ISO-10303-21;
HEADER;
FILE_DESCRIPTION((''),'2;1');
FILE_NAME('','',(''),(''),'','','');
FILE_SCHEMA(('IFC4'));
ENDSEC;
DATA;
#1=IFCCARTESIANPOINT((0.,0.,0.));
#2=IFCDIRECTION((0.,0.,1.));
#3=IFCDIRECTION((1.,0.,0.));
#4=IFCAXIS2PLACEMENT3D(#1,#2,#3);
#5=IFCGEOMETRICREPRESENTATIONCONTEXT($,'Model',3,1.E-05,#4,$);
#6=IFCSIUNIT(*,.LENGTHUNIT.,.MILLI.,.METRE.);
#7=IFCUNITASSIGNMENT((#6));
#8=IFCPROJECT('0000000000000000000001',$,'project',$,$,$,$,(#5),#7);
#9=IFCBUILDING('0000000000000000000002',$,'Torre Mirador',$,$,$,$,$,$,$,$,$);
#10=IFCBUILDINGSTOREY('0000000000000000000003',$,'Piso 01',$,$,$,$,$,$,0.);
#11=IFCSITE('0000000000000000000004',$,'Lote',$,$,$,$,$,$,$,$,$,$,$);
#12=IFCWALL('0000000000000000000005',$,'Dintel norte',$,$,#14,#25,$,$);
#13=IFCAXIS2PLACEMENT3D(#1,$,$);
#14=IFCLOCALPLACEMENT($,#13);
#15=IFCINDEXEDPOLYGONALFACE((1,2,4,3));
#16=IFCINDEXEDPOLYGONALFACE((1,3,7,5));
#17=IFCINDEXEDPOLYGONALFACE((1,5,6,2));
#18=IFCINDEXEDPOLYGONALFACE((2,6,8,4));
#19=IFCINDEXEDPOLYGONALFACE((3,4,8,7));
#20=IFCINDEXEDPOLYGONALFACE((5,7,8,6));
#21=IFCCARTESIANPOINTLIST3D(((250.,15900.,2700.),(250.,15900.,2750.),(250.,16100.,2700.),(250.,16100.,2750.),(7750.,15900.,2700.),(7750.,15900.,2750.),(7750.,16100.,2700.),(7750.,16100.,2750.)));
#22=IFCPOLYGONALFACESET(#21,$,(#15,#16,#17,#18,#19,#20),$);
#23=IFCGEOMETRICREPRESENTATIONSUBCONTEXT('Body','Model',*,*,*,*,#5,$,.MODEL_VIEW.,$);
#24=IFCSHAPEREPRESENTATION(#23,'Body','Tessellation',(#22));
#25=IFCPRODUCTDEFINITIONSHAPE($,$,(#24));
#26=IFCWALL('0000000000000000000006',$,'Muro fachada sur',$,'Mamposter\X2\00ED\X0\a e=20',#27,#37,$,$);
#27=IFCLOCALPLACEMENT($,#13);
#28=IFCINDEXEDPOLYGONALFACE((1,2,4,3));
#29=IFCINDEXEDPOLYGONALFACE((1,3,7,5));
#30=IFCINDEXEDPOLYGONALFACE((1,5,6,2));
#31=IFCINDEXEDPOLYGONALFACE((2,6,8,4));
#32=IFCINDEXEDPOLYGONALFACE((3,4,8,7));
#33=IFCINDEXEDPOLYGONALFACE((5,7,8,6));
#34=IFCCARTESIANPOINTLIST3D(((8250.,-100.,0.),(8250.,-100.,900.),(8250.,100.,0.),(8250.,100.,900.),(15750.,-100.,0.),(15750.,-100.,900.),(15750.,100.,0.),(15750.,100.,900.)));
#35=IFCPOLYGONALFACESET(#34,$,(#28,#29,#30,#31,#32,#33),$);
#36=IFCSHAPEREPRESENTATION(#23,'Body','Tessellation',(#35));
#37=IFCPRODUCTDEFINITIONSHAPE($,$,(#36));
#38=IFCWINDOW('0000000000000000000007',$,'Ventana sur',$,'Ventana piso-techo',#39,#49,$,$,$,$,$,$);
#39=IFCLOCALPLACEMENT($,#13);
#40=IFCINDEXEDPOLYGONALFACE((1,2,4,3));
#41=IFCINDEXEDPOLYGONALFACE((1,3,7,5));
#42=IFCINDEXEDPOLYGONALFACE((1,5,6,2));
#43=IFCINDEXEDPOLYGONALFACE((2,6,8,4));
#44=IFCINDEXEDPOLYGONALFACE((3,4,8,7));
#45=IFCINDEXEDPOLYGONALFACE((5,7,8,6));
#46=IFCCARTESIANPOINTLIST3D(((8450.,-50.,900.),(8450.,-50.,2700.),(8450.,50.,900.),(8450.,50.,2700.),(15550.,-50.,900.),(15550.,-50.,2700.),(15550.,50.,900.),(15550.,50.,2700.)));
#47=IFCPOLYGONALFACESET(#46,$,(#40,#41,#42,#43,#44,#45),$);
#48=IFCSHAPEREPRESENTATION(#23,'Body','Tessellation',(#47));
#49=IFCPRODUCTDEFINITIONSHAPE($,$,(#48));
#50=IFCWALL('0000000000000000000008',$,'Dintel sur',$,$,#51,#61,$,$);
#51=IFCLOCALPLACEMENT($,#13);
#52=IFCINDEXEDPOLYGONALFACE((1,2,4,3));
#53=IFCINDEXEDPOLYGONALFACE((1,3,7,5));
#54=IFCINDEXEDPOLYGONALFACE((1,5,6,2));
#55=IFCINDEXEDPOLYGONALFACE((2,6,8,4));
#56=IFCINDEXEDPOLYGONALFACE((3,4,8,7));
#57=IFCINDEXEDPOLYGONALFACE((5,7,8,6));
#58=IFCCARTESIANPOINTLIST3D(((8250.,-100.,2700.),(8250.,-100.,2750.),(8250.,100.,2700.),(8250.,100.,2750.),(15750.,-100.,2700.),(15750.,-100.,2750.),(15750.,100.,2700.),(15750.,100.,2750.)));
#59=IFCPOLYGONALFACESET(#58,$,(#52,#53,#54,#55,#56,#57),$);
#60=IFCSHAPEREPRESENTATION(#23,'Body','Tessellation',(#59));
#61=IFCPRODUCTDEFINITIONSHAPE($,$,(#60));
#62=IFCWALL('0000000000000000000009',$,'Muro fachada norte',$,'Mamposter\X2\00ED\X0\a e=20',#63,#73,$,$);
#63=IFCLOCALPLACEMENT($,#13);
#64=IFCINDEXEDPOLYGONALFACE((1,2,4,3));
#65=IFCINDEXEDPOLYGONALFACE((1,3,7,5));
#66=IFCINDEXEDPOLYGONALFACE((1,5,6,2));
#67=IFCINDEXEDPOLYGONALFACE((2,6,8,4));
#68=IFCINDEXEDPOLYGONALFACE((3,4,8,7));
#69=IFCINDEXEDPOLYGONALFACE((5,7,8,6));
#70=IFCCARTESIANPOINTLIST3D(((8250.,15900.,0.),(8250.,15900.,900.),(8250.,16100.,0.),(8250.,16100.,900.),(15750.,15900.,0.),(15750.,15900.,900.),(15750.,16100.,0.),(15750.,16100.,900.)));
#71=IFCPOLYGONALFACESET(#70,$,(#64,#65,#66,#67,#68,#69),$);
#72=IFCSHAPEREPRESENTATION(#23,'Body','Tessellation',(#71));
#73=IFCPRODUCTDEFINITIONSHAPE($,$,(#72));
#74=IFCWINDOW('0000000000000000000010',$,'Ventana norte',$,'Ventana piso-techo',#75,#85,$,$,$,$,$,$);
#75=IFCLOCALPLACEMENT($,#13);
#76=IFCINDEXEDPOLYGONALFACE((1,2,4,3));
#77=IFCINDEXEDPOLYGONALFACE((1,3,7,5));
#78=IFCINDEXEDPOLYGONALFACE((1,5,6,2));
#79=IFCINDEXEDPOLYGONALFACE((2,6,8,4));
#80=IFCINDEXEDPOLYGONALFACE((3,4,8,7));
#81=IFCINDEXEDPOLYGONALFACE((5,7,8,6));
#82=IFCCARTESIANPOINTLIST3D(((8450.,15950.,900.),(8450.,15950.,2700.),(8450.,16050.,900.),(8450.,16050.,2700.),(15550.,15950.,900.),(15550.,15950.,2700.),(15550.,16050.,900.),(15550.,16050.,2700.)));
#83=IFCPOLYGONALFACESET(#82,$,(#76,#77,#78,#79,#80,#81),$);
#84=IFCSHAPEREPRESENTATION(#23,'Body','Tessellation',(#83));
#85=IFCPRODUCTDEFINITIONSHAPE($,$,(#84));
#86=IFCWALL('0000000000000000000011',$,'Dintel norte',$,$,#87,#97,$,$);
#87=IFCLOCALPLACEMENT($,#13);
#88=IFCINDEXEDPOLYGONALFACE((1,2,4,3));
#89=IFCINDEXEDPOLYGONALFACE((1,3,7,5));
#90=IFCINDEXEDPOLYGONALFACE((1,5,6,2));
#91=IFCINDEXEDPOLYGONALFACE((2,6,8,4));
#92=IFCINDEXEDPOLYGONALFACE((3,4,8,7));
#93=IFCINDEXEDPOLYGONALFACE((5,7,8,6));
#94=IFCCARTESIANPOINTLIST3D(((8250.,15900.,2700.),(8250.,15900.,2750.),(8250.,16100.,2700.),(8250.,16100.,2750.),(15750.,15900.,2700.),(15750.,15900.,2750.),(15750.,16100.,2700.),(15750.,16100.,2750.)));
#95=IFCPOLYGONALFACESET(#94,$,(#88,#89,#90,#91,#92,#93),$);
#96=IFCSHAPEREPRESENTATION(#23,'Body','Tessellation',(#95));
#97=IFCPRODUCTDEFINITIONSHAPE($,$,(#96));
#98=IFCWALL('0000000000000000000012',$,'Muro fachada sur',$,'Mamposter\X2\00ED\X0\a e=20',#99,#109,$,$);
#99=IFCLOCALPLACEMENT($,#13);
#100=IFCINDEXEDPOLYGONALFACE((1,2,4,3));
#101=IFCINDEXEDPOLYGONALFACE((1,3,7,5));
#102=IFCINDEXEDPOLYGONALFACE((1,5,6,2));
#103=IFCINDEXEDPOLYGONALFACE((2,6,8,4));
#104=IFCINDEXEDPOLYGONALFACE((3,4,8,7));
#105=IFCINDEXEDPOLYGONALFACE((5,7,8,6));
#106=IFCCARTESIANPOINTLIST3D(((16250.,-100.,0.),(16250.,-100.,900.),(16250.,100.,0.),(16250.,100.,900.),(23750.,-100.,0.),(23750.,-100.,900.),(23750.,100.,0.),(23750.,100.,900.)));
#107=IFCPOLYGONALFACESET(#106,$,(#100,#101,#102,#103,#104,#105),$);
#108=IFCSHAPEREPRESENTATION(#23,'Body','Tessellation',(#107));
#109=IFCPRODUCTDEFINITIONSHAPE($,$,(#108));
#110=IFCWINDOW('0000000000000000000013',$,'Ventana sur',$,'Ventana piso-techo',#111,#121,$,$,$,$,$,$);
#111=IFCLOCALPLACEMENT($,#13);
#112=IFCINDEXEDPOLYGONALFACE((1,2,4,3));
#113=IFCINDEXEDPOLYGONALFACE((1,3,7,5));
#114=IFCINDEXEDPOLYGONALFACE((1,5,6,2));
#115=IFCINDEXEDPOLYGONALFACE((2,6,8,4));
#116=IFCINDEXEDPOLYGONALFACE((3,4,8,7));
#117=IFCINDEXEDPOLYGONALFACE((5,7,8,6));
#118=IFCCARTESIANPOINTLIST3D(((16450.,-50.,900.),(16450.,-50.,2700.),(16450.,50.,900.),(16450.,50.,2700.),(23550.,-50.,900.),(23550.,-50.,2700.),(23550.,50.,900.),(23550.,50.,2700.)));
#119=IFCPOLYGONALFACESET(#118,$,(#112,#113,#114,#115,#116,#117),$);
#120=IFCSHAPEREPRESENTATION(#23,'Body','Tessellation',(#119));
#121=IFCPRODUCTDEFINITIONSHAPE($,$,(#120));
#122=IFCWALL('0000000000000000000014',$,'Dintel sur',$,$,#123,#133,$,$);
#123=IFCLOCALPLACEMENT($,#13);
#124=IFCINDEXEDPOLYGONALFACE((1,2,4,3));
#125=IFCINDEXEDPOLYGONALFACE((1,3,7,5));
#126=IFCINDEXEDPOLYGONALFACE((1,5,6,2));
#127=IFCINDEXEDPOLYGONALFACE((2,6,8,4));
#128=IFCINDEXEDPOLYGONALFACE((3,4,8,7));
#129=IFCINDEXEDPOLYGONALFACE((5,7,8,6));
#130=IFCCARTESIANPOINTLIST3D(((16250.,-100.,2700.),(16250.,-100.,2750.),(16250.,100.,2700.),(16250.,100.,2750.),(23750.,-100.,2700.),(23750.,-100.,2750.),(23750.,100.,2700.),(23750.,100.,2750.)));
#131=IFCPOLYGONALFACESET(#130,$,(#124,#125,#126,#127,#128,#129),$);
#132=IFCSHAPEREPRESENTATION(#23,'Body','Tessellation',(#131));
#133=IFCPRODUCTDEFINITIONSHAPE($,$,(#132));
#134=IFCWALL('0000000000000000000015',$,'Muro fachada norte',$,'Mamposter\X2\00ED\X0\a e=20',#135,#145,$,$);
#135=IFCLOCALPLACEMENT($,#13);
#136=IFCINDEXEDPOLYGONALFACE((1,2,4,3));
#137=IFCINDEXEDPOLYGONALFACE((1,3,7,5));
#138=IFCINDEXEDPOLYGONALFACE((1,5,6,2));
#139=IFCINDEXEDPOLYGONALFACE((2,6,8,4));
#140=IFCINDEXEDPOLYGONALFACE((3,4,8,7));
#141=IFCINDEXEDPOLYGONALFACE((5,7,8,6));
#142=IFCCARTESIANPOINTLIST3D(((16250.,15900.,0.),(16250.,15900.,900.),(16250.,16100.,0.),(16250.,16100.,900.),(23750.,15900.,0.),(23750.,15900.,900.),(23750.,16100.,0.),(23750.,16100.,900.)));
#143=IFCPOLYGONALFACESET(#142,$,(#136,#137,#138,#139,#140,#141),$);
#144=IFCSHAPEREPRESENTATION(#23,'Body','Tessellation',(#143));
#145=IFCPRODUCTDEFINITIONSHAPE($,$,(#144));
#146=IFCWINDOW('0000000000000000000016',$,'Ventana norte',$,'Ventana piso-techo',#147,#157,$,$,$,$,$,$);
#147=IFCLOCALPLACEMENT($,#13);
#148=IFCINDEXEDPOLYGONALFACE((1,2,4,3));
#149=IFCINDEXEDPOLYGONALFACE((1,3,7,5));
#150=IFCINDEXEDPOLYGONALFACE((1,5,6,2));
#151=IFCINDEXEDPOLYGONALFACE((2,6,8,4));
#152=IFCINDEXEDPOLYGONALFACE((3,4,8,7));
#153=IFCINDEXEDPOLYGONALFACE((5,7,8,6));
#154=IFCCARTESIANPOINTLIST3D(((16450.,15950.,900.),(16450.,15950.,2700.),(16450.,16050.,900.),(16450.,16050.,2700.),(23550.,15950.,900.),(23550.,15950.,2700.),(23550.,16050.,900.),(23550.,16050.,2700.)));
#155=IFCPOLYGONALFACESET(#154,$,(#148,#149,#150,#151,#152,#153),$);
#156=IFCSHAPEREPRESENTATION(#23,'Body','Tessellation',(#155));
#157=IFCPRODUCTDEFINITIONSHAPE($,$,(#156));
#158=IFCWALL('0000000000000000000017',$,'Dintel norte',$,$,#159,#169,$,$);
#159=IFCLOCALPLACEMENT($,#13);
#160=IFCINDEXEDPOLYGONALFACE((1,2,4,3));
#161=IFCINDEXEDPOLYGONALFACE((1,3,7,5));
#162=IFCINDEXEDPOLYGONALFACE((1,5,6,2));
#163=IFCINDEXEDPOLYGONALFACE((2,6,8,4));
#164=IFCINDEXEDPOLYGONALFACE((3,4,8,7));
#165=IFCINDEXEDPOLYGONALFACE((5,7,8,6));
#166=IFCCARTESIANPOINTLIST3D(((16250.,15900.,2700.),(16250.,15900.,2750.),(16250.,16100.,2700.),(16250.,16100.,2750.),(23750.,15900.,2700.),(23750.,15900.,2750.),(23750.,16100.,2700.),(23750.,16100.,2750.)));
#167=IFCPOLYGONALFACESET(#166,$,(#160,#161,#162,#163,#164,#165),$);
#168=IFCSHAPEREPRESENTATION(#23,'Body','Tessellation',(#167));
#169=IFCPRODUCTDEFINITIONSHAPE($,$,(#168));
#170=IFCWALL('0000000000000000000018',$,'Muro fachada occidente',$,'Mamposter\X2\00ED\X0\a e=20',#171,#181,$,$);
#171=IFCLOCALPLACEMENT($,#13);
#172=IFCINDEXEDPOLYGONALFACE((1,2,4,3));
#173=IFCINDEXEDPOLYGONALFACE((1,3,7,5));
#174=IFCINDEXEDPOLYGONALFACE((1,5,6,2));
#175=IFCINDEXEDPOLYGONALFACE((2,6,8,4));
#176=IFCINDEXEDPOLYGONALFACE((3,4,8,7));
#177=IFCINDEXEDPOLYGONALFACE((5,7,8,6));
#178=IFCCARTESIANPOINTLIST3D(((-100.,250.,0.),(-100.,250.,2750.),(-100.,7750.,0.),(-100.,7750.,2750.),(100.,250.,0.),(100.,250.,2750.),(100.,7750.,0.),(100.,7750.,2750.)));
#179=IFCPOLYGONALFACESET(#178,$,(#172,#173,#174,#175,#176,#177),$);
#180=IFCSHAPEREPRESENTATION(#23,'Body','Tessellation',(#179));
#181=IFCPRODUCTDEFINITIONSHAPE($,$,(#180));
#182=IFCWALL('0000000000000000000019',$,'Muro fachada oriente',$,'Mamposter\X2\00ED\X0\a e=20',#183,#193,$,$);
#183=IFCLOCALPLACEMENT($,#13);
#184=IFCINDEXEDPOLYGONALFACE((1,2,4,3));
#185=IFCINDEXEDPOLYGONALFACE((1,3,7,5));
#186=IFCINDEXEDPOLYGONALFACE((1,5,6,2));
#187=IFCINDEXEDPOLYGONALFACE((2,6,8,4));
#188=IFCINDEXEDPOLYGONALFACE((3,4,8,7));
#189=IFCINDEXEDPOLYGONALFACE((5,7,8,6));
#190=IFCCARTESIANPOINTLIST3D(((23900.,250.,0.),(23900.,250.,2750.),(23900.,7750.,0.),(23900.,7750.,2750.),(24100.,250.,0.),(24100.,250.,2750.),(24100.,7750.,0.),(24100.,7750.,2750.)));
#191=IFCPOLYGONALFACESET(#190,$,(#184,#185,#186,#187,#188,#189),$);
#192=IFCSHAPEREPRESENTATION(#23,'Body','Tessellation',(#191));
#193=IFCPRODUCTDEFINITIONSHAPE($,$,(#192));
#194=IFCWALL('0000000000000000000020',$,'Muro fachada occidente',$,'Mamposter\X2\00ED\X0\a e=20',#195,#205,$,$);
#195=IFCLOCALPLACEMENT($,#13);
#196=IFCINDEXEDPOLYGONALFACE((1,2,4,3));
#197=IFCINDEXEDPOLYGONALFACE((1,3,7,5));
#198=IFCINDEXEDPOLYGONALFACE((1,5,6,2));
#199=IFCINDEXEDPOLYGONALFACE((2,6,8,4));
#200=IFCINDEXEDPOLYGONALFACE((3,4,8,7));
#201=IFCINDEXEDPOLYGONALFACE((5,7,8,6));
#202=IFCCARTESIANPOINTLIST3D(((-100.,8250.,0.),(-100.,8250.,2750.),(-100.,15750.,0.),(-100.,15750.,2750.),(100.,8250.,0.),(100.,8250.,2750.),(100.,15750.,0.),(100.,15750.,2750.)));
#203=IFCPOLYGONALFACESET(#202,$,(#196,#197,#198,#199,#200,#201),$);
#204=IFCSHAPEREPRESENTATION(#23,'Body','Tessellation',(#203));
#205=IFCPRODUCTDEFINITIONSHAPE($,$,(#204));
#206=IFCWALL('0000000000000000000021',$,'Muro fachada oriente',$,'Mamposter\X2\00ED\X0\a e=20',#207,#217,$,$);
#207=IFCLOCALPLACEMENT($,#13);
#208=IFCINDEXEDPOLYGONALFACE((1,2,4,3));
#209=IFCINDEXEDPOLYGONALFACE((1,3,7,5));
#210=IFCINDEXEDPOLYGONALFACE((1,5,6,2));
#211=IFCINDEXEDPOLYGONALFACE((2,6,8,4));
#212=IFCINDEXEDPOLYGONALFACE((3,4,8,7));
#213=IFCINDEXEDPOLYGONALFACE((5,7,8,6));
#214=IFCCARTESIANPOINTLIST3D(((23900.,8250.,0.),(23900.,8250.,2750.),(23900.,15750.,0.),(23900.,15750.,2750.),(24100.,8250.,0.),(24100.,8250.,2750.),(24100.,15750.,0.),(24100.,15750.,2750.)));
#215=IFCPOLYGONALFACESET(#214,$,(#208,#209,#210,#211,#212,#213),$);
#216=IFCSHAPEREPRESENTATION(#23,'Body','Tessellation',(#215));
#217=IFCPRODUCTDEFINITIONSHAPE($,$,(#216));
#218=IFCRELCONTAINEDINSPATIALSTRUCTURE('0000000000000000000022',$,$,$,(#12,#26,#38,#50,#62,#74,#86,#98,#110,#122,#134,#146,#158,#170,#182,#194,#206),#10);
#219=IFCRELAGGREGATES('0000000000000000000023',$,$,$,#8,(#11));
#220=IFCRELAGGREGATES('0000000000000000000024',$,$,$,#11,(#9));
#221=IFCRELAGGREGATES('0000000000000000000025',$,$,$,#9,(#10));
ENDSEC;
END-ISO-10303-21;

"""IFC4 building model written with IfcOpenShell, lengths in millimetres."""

from ifc_helpers import new_model, si_unit, frame, origin_with_axes, place, context, subcontext, project, spatial, indexed_curve, outline, extrude, element, save


model = new_model("IFC4")

# Units and contexts
model_context = context("Model", 3, precision=1e-05, world=origin_with_axes())
body_context = subcontext(model_context, "Body", "Model", "MODEL_VIEW")
ifc_project = project(units=[si_unit("LENGTHUNIT", "METRE", prefix="MILLI")], contexts=[model_context])

# Site, building, storey
site = spatial("IfcSite", under=ifc_project, Name="Lote")
building = spatial("IfcBuilding", under=site, Name="Torre Mirador")
storey = spatial("IfcBuildingStorey", under=building, Name="Piso 01", Elevation=0.0)

# Walls
wall_1_placement = place(None, frame((250.0, 15900.0, 2700.0), z_axis=(0.0, 0.0, 1.0), x_axis=(1.0, 0.0, 0.0)))
element("IfcWall", 1, at=wall_1_placement, inside=storey, Name="Dintel norte", context=body_context, shape_type="SweptSolid", body=[
    extrude(outline(indexed_curve([(0.0, 0.0), (0.0, 200.0), (7500.0, 200.0), (7500.0, 0.0), (0.0, 0.0)], self_intersect=False)), origin_with_axes(), (0.0, 0.0, 1.0), 50.0),
])
wall_2_placement = place(None, frame((8250.0, -100.0, 0.0), z_axis=(0.0, 0.0, 1.0), x_axis=(1.0, 0.0, 0.0)))
element("IfcWall", 2, at=wall_2_placement, inside=storey, Name="Muro fachada sur", ObjectType="Mampostería e=20", context=body_context, shape_type="SweptSolid", body=[
    extrude(outline(indexed_curve([(0.0, 0.0), (0.0, 200.0), (7500.0, 200.0), (7500.0, 0.0), (0.0, 0.0)], self_intersect=False)), origin_with_axes(), (0.0, 0.0, 1.0), 900.0),
])

# Window
window_1_placement = place(None, frame((8450.0, -50.0, 900.0), z_axis=(0.0, 0.0, 1.0), x_axis=(1.0, 0.0, 0.0)))
element("IfcWindow", 3, at=window_1_placement, inside=storey, Name="Ventana sur", ObjectType="Ventana piso-techo", context=body_context, shape_type="SweptSolid", body=[
    extrude(outline(indexed_curve([(0.0, 0.0), (0.0, 100.0), (7100.0, 100.0), (7100.0, 0.0), (0.0, 0.0)], self_intersect=False)), origin_with_axes(), (0.0, 0.0, 1.0), 1800.0),
])

# Walls
wall_3_placement = place(None, frame((8250.0, -100.0, 2700.0), z_axis=(0.0, 0.0, 1.0), x_axis=(1.0, 0.0, 0.0)))
element("IfcWall", 4, at=wall_3_placement, inside=storey, Name="Dintel sur", context=body_context, shape_type="SweptSolid", body=[
    extrude(outline(indexed_curve([(0.0, 0.0), (0.0, 200.0), (7500.0, 200.0), (7500.0, 0.0), (0.0, 0.0)], self_intersect=False)), origin_with_axes(), (0.0, 0.0, 1.0), 50.0),
])
wall_4_placement = place(None, frame((8250.0, 15900.0, 0.0), z_axis=(0.0, 0.0, 1.0), x_axis=(1.0, 0.0, 0.0)))
element("IfcWall", 5, at=wall_4_placement, inside=storey, Name="Muro fachada norte", ObjectType="Mampostería e=20", context=body_context, shape_type="SweptSolid", body=[
    extrude(outline(indexed_curve([(0.0, 0.0), (0.0, 200.0), (7500.0, 200.0), (7500.0, 0.0), (0.0, 0.0)], self_intersect=False)), origin_with_axes(), (0.0, 0.0, 1.0), 900.0),
])

# Window
window_2_placement = place(None, frame((8450.0, 15950.0, 900.0), z_axis=(0.0, 0.0, 1.0), x_axis=(1.0, 0.0, 0.0)))
element("IfcWindow", 6, at=window_2_placement, inside=storey, Name="Ventana norte", ObjectType="Ventana piso-techo", context=body_context, shape_type="SweptSolid", body=[
    extrude(outline(indexed_curve([(0.0, 0.0), (0.0, 100.0), (7100.0, 100.0), (7100.0, 0.0), (0.0, 0.0)], self_intersect=False)), origin_with_axes(), (0.0, 0.0, 1.0), 1800.0),
])

# Walls
wall_5_placement = place(None, frame((8250.0, 15900.0, 2700.0), z_axis=(0.0, 0.0, 1.0), x_axis=(1.0, 0.0, 0.0)))
element("IfcWall", 7, at=wall_5_placement, inside=storey, Name="Dintel norte", context=body_context, shape_type="SweptSolid", body=[
    extrude(outline(indexed_curve([(0.0, 0.0), (0.0, 200.0), (7500.0, 200.0), (7500.0, 0.0), (0.0, 0.0)], self_intersect=False)), origin_with_axes(), (0.0, 0.0, 1.0), 50.0),
])
wall_6_placement = place(None, frame((16250.0, -100.0, 0.0), z_axis=(0.0, 0.0, 1.0), x_axis=(1.0, 0.0, 0.0)))
element("IfcWall", 8, at=wall_6_placement, inside=storey, Name="Muro fachada sur", ObjectType="Mampostería e=20", context=body_context, shape_type="SweptSolid", body=[
    extrude(outline(indexed_curve([(0.0, 0.0), (0.0, 200.0), (7500.0, 200.0), (7500.0, 0.0), (0.0, 0.0)], self_intersect=False)), origin_with_axes(), (0.0, 0.0, 1.0), 900.0),
])

# Window
window_3_placement = place(None, frame((16450.0, -50.0, 900.0), z_axis=(0.0, 0.0, 1.0), x_axis=(1.0, 0.0, 0.0)))
element("IfcWindow", 9, at=window_3_placement, inside=storey, Name="Ventana sur", ObjectType="Ventana piso-techo", context=body_context, shape_type="SweptSolid", body=[
    extrude(outline(indexed_curve([(0.0, 0.0), (0.0, 100.0), (7100.0, 100.0), (7100.0, 0.0), (0.0, 0.0)], self_intersect=False)), origin_with_axes(), (0.0, 0.0, 1.0), 1800.0),
])

# Walls
wall_7_placement = place(None, frame((16250.0, -100.0, 2700.0), z_axis=(0.0, 0.0, 1.0), x_axis=(1.0, 0.0, 0.0)))
element("IfcWall", 10, at=wall_7_placement, inside=storey, Name="Dintel sur", context=body_context, shape_type="SweptSolid", body=[
    extrude(outline(indexed_curve([(0.0, 0.0), (0.0, 200.0), (7500.0, 200.0), (7500.0, 0.0), (0.0, 0.0)], self_intersect=False)), origin_with_axes(), (0.0, 0.0, 1.0), 50.0),
])
wall_8_placement = place(None, frame((16250.0, 15900.0, 0.0), z_axis=(0.0, 0.0, 1.0), x_axis=(1.0, 0.0, 0.0)))
element("IfcWall", 11, at=wall_8_placement, inside=storey, Name="Muro fachada norte", ObjectType="Mampostería e=20", context=body_context, shape_type="SweptSolid", body=[
    extrude(outline(indexed_curve([(0.0, 0.0), (0.0, 200.0), (7500.0, 200.0), (7500.0, 0.0), (0.0, 0.0)], self_intersect=False)), origin_with_axes(), (0.0, 0.0, 1.0), 900.0),
])

# Window
window_4_placement = place(None, frame((16450.0, 15950.0, 900.0), z_axis=(0.0, 0.0, 1.0), x_axis=(1.0, 0.0, 0.0)))
element("IfcWindow", 12, at=window_4_placement, inside=storey, Name="Ventana norte", ObjectType="Ventana piso-techo", context=body_context, shape_type="SweptSolid", body=[
    extrude(outline(indexed_curve([(0.0, 0.0), (0.0, 100.0), (7100.0, 100.0), (7100.0, 0.0), (0.0, 0.0)], self_intersect=False)), origin_with_axes(), (0.0, 0.0, 1.0), 1800.0),
])

# Walls
wall_9_placement = place(None, frame((16250.0, 15900.0, 2700.0), z_axis=(0.0, 0.0, 1.0), x_axis=(1.0, 0.0, 0.0)))
element("IfcWall", 13, at=wall_9_placement, inside=storey, Name="Dintel norte", context=body_context, shape_type="SweptSolid", body=[
    extrude(outline(indexed_curve([(0.0, 0.0), (0.0, 200.0), (7500.0, 200.0), (7500.0, 0.0), (0.0, 0.0)], self_intersect=False)), origin_with_axes(), (0.0, 0.0, 1.0), 50.0),
])
for number, where, z_axis, x_axis, name in (
    (14, (-100.0, 250.0, 0.0), (0.0, 0.0, 1.0), (1.0, 0.0, 0.0), "Muro fachada occidente"),
    (15, (23900.0, 250.0, 0.0), (0.0, 0.0, 1.0), (1.0, 0.0, 0.0), "Muro fachada oriente"),
    (16, (-100.0, 8250.0, 0.0), (0.0, 0.0, 1.0), (1.0, 0.0, 0.0), "Muro fachada occidente"),
    (17, (23900.0, 8250.0, 0.0), (0.0, 0.0, 1.0), (1.0, 0.0, 0.0), "Muro fachada oriente"),
):
    element("IfcWall", number, at=place(None, frame(where, z_axis=z_axis, x_axis=x_axis)), inside=storey, Name=name, ObjectType="Mampostería e=20", context=body_context, shape_type="SweptSolid", body=[
        extrude(outline(indexed_curve([(0.0, 0.0), (0.0, 7500.0), (200.0, 7500.0), (200.0, 0.0), (0.0, 0.0)], self_intersect=False)), origin_with_axes(), (0.0, 0.0, 1.0), 2750.0),
    ])

save(model, "model.ifc")
